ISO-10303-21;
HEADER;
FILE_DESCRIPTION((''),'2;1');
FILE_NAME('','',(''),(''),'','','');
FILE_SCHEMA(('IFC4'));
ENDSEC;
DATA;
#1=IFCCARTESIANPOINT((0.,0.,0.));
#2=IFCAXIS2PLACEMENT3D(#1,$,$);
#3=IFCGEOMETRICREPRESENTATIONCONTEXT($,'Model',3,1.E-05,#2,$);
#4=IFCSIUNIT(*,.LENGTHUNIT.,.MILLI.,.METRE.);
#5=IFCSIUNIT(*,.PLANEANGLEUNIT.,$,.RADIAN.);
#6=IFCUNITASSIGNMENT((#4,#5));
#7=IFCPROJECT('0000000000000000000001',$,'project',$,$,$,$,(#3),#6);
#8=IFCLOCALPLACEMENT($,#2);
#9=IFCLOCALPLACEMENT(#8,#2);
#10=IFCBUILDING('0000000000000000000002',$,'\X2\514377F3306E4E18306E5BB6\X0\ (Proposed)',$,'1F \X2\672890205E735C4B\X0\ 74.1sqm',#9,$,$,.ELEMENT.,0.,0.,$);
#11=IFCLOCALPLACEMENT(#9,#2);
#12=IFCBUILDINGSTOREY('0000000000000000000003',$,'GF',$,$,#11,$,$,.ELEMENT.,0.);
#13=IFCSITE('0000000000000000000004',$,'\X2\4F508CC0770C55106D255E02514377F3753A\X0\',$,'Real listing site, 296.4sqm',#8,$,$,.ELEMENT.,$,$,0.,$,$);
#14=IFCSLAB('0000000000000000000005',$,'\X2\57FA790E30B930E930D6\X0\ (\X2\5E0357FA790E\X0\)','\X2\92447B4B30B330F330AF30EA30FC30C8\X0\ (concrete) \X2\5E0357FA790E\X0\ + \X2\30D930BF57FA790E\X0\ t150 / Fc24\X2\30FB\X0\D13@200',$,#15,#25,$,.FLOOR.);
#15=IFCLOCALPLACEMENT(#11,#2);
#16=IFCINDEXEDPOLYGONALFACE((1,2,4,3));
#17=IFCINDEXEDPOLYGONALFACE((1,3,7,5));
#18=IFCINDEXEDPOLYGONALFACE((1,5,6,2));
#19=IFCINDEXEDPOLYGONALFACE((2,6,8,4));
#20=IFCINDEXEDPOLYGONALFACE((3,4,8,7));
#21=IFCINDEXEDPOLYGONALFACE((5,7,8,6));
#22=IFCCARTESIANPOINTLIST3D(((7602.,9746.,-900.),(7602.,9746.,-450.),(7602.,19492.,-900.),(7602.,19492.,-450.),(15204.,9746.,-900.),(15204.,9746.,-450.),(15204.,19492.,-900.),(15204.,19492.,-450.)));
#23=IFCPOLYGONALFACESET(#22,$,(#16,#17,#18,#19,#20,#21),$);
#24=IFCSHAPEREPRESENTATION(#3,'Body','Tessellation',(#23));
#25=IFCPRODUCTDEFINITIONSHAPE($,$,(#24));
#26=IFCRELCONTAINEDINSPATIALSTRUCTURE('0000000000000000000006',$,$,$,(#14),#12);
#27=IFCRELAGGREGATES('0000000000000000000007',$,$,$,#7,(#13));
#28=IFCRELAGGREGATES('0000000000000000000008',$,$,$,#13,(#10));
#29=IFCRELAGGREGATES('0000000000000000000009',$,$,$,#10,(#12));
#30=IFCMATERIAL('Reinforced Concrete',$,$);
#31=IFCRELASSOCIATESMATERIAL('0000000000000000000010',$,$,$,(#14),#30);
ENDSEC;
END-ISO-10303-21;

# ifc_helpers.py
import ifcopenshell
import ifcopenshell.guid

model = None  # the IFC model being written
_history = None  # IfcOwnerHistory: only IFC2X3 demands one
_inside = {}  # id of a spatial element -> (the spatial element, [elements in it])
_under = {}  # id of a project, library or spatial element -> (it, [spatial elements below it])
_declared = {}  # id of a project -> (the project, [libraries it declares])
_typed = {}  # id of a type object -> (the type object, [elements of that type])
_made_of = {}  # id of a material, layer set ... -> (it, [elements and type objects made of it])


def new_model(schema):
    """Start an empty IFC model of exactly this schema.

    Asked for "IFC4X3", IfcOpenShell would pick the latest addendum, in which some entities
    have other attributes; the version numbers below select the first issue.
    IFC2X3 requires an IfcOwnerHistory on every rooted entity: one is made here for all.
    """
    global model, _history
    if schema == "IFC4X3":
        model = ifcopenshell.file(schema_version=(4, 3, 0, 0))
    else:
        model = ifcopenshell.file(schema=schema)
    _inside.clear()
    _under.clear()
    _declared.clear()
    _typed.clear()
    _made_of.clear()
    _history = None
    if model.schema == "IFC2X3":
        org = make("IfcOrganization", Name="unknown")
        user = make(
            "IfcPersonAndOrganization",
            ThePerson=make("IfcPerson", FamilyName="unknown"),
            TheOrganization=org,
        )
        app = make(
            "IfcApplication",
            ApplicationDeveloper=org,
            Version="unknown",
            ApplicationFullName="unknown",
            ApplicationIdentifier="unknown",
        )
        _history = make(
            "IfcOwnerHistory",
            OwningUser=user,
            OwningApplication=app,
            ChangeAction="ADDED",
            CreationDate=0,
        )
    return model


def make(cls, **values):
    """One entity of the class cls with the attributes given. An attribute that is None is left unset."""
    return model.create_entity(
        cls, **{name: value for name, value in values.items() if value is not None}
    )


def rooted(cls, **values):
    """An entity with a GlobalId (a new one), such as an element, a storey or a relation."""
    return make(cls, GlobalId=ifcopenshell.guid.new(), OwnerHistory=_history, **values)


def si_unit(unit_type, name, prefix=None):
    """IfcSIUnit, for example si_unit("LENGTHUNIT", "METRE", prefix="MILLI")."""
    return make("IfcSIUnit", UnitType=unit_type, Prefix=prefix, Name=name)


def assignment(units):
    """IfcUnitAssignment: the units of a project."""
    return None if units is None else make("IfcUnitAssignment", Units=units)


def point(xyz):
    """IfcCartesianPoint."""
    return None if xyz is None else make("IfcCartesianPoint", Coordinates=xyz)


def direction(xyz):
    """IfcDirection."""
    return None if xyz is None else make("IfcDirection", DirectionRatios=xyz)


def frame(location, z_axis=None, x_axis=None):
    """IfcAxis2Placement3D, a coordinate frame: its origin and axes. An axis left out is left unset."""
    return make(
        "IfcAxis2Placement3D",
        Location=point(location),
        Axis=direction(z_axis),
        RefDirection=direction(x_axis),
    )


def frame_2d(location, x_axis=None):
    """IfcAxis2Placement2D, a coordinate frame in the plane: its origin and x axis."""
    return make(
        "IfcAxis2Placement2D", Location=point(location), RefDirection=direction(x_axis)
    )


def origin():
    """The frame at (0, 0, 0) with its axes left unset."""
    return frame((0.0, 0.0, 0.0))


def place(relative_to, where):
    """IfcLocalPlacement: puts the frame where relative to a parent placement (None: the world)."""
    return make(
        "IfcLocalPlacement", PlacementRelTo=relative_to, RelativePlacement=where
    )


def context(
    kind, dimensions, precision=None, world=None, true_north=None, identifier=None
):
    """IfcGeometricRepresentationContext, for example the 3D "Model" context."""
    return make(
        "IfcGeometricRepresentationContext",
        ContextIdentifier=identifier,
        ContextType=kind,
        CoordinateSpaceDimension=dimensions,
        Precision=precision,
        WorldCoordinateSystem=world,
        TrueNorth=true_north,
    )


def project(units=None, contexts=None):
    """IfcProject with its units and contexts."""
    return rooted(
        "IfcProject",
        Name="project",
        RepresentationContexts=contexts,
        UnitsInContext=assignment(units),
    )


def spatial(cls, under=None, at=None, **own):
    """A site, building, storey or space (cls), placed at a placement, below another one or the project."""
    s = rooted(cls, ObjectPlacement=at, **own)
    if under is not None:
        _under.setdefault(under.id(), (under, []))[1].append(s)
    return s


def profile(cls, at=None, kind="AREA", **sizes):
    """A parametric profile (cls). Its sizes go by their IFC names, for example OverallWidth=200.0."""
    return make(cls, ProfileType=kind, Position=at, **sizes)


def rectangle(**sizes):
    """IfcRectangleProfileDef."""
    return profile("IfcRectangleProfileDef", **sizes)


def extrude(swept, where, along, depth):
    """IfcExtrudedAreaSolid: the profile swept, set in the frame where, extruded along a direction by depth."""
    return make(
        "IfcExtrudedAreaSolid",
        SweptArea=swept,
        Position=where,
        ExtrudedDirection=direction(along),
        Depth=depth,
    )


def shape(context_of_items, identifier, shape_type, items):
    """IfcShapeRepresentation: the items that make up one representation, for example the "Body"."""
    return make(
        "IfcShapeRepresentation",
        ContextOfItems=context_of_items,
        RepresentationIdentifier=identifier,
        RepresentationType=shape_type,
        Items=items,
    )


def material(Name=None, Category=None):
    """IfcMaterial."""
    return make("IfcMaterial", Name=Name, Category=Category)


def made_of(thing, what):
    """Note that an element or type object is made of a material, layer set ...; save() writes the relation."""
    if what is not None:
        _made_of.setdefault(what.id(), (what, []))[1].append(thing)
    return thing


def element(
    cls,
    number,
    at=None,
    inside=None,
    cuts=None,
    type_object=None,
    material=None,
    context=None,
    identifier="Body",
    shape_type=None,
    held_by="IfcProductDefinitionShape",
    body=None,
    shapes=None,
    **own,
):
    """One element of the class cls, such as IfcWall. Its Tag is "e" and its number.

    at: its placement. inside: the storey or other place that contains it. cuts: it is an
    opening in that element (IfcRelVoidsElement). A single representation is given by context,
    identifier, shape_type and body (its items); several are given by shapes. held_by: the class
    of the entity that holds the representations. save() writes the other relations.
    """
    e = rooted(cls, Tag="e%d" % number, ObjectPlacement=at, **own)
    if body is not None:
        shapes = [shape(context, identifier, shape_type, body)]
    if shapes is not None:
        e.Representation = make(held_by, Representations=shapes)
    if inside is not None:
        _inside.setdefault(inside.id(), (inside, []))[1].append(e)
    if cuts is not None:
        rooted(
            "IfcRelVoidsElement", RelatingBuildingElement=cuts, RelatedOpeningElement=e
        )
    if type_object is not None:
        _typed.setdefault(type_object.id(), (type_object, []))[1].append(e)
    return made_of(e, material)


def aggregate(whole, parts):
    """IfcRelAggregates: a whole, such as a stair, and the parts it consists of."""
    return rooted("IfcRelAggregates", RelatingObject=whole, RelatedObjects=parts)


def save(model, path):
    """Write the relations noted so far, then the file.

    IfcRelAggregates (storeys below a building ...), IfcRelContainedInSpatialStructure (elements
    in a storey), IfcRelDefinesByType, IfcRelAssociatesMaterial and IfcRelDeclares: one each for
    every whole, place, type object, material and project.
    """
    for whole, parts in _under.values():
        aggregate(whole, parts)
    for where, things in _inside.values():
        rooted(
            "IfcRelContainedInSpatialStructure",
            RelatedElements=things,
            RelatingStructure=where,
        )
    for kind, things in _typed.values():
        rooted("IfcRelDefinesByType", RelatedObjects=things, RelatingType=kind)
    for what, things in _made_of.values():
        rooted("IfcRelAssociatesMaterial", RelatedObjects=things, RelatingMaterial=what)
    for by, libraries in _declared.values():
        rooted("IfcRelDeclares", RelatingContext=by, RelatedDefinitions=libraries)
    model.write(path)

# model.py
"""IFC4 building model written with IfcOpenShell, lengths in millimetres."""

from ifc_helpers import new_model, si_unit, frame, frame_2d, origin, place, context, project, spatial, rectangle, extrude, material, element, save


model = new_model("IFC4")

# Units and contexts
model_context = context("Model", 3, precision=1e-05, world=origin())
ifc_project = project(units=[si_unit("LENGTHUNIT", "METRE", prefix="MILLI"), si_unit("PLANEANGLEUNIT", "RADIAN")], contexts=[model_context])

# Site, building, storey
site_placement = place(None, origin())
site = spatial("IfcSite", under=ifc_project, at=site_placement, Name="佐賀県唐津市元石町", ObjectType="Real listing site, 296.4sqm", CompositionType="ELEMENT", RefElevation=0.0)
building_placement = place(site_placement, origin())
building = spatial("IfcBuilding", under=site, at=building_placement, Name="元石の丘の家 (Proposed)", ObjectType="1F 木造平屋 74.1sqm", CompositionType="ELEMENT", ElevationOfRefHeight=0.0, ElevationOfTerrain=0.0)
storey_placement = place(building_placement, origin())
storey = spatial("IfcBuildingStorey", under=building, at=storey_placement, Name="GF", CompositionType="ELEMENT", Elevation=0.0)

# Slab
ifc_material_1 = material(Name="Reinforced Concrete")
slab_1_placement = place(storey_placement, frame((3801.0, 4873.0, -450.0)))
element("IfcSlab", 1, at=slab_1_placement, inside=storey, material=ifc_material_1, Name="基礎スラブ (布基礎)", Description="鉄筋コンクリート (concrete) 布基礎 + ベタ基礎 t150 / Fc24・D13@200", PredefinedType="FLOOR", context=model_context, shape_type="SweptSolid", body=[
    extrude(rectangle(XDim=7602.0, YDim=9746.0, at=frame_2d((3801.0, 4873.0))), frame((3801.0, 4873.0, -450.0)), (0.0, 0.0, 1.0), 450.0),
])

save(model, "model.ifc")
